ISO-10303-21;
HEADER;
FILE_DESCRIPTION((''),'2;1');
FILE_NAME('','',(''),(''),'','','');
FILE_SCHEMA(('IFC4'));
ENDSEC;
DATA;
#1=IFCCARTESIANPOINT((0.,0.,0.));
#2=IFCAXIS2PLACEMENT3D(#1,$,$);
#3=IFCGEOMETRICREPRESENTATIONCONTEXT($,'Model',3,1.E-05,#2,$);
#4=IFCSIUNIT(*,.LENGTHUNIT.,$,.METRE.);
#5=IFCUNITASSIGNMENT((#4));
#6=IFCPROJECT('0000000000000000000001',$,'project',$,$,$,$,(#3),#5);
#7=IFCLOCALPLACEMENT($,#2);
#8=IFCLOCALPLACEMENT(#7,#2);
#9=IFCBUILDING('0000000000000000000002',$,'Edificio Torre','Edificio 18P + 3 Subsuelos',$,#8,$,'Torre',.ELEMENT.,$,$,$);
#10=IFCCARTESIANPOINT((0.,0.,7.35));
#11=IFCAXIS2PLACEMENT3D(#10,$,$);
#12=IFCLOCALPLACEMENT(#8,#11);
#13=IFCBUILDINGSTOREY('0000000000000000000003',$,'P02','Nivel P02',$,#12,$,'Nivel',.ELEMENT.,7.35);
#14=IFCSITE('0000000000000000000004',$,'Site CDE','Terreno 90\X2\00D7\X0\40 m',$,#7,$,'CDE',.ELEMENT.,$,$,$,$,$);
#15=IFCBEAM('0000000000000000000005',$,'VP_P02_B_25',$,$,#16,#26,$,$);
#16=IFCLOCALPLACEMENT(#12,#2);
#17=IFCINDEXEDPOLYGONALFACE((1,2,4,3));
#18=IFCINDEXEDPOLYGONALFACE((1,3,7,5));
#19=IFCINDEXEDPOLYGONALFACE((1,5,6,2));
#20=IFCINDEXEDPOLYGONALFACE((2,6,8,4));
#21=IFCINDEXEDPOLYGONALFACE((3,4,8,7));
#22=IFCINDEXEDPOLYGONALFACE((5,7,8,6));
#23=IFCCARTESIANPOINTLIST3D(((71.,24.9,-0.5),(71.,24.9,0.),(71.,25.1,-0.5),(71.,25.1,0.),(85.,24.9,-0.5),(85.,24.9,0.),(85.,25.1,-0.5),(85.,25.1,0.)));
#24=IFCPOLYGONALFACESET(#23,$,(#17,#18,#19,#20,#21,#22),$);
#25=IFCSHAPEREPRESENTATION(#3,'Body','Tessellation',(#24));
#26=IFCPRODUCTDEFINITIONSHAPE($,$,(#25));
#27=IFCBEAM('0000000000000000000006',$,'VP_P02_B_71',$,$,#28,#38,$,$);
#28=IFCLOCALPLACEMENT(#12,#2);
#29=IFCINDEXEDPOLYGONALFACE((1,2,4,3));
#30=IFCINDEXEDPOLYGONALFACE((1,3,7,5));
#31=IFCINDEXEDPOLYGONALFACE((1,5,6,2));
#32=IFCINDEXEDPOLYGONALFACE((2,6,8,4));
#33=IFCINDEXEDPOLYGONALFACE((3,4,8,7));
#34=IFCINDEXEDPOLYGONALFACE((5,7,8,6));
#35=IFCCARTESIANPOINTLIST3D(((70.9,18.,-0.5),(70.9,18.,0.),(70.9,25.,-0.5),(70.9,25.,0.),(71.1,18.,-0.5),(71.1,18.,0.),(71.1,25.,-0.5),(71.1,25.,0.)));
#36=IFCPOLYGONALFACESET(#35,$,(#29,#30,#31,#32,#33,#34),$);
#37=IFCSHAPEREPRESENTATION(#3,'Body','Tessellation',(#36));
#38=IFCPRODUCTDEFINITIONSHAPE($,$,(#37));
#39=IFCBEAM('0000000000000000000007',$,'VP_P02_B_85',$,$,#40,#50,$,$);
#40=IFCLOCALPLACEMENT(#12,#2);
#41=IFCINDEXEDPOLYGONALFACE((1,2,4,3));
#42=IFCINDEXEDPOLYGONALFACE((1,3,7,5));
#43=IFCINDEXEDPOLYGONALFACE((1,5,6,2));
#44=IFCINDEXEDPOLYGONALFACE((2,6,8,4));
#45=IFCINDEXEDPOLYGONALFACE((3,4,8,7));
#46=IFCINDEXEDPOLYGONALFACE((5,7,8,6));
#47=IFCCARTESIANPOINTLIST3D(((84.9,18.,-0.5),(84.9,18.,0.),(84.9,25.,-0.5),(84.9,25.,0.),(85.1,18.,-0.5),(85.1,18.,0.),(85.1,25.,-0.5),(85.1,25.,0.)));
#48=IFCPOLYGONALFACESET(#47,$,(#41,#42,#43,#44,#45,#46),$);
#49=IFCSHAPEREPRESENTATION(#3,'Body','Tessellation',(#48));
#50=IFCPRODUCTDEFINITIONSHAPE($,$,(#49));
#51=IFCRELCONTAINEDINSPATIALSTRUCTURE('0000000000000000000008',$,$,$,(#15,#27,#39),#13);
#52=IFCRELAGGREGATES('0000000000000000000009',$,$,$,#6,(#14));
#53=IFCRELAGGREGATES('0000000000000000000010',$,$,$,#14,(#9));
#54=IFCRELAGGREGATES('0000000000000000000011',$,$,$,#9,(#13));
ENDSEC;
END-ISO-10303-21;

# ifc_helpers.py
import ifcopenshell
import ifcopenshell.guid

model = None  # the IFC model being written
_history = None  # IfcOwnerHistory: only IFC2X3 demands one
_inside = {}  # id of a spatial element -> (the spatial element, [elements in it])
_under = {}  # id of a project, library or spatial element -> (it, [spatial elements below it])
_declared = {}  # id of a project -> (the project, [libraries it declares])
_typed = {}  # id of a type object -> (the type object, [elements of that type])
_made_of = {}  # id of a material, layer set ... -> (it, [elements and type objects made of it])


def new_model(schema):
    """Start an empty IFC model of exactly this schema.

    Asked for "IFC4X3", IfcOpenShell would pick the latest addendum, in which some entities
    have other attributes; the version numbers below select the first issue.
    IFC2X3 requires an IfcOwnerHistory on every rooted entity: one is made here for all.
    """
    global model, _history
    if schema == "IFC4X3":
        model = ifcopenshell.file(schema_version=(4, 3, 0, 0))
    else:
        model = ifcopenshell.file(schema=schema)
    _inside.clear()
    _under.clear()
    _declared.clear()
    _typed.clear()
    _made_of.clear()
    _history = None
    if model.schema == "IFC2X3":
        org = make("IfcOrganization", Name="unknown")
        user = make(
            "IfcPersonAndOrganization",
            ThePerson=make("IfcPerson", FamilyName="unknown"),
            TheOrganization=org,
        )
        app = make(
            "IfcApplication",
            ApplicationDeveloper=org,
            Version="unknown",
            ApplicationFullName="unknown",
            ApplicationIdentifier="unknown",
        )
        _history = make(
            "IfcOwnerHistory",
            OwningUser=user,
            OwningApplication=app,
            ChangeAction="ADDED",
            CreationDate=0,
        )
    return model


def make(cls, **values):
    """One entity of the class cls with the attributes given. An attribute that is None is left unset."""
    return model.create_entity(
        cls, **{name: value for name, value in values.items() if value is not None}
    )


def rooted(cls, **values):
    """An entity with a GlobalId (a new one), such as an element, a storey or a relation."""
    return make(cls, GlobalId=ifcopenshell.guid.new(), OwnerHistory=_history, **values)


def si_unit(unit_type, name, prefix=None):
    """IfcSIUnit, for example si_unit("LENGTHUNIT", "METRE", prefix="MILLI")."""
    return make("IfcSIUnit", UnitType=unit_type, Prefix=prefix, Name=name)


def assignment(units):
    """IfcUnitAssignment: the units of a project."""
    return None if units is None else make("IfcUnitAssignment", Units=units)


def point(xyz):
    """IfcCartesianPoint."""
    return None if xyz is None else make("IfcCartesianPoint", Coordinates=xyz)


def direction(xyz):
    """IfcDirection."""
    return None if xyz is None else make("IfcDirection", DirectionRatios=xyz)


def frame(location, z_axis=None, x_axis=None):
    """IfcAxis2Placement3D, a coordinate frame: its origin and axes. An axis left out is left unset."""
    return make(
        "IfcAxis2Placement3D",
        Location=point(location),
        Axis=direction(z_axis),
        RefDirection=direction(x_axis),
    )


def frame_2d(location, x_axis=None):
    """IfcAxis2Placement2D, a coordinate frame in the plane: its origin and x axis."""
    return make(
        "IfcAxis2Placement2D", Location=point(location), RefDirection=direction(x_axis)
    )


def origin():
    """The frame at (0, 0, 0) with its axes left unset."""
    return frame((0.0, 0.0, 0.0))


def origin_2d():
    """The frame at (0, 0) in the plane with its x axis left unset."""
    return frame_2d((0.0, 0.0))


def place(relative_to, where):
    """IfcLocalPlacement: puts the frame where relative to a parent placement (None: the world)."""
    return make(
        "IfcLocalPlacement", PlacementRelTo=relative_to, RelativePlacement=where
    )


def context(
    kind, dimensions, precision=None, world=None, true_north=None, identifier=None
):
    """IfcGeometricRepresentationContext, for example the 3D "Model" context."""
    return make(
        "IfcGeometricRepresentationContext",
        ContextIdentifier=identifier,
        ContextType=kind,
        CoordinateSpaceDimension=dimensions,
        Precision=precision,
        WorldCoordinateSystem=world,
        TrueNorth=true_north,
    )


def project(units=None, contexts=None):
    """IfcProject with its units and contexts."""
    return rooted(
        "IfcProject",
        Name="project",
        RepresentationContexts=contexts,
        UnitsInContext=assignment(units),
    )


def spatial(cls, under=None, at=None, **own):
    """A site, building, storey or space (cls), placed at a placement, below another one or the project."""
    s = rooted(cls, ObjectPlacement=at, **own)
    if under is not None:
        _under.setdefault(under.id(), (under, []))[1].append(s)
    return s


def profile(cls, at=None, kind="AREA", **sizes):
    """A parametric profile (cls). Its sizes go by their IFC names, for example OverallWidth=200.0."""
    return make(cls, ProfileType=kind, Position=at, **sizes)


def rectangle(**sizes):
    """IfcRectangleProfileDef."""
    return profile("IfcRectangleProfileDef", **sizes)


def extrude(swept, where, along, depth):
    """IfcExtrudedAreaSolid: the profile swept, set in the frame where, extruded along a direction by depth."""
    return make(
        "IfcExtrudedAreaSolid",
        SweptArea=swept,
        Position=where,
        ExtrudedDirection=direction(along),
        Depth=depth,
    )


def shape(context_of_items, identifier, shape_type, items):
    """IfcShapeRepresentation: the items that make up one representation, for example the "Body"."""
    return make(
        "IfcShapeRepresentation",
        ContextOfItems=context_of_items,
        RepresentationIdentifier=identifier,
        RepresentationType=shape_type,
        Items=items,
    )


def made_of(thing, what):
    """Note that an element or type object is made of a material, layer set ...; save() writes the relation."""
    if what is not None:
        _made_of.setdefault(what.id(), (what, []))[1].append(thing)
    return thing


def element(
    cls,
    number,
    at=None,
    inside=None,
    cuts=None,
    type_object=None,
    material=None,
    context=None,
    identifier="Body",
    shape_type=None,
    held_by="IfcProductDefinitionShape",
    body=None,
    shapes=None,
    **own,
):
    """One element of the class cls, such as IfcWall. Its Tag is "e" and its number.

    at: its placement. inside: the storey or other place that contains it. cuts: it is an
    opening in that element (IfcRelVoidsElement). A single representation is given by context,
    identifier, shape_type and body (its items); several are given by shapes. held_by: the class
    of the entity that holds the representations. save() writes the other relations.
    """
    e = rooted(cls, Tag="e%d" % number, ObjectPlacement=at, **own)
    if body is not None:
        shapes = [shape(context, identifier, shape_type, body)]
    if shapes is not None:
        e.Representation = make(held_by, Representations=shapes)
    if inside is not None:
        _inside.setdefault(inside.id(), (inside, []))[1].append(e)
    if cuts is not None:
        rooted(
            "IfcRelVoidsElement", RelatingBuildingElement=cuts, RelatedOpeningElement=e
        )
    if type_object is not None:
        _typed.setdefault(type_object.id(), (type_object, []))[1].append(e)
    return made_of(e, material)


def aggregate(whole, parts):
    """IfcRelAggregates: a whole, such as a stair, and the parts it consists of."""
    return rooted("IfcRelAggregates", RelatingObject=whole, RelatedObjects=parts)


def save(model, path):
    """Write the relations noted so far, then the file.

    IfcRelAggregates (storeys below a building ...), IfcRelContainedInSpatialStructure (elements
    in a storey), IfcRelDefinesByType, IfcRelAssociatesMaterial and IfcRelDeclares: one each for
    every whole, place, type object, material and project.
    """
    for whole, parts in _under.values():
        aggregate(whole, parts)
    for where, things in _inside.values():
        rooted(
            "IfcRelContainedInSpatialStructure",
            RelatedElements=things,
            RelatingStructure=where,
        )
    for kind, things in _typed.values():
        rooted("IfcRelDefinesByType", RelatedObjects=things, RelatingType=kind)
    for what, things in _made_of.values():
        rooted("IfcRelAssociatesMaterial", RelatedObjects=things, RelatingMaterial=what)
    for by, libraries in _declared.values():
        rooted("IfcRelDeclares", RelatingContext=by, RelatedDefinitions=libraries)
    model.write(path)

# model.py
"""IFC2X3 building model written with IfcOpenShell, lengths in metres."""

from ifc_helpers import new_model, si_unit, frame, origin, origin_2d, place, context, project, spatial, rectangle, extrude, element, save


model = new_model("IFC2X3")

# Units and contexts
model_context = context("Model", 3, precision=1e-05, world=origin())
ifc_project = project(units=[si_unit("LENGTHUNIT", "METRE")], contexts=[model_context])

# Site, building, storey
site_placement = place(None, origin())
site = spatial("IfcSite", under=ifc_project, at=site_placement, Name="Site CDE", Description="Terreno 90×40 m", LongName="CDE", CompositionType="ELEMENT")
building_placement = place(site_placement, origin())
building = spatial("IfcBuilding", under=site, at=building_placement, Name="Edificio Torre", Description="Edificio 18P + 3 Subsuelos", LongName="Torre", CompositionType="ELEMENT")
storey_placement = place(building_placement, frame((0.0, 0.0, 7.35)))
storey = spatial("IfcBuildingStorey", under=building, at=storey_placement, Name="P02", Description="Nivel P02", LongName="Nivel", CompositionType="ELEMENT", Elevation=7.35)

# Beams
for number, where, name in (
    (1, (78.0, 25.0, -0.5), "VP_P02_B_25"),
):
    element("IfcBeam", number, at=place(storey_placement, frame(where)), inside=storey, Name=name, context=model_context, shape_type="SweptSolid", body=[
        extrude(rectangle(XDim=14.0, YDim=0.2, at=origin_2d()), origin(), (0.0, 0.0, 1.0), 0.5),
    ])
for number, where, name in (
    (2, (71.0, 21.5, -0.5), "VP_P02_B_71"),
    (3, (85.0, 21.5, -0.5), "VP_P02_B_85"),
):
    element("IfcBeam", number, at=place(storey_placement, frame(where)), inside=storey, Name=name, context=model_context, shape_type="SweptSolid", body=[
        extrude(rectangle(XDim=0.2, YDim=7.0, at=origin_2d()), origin(), (0.0, 0.0, 1.0), 0.5),
    ])

save(model, "model.ifc")
